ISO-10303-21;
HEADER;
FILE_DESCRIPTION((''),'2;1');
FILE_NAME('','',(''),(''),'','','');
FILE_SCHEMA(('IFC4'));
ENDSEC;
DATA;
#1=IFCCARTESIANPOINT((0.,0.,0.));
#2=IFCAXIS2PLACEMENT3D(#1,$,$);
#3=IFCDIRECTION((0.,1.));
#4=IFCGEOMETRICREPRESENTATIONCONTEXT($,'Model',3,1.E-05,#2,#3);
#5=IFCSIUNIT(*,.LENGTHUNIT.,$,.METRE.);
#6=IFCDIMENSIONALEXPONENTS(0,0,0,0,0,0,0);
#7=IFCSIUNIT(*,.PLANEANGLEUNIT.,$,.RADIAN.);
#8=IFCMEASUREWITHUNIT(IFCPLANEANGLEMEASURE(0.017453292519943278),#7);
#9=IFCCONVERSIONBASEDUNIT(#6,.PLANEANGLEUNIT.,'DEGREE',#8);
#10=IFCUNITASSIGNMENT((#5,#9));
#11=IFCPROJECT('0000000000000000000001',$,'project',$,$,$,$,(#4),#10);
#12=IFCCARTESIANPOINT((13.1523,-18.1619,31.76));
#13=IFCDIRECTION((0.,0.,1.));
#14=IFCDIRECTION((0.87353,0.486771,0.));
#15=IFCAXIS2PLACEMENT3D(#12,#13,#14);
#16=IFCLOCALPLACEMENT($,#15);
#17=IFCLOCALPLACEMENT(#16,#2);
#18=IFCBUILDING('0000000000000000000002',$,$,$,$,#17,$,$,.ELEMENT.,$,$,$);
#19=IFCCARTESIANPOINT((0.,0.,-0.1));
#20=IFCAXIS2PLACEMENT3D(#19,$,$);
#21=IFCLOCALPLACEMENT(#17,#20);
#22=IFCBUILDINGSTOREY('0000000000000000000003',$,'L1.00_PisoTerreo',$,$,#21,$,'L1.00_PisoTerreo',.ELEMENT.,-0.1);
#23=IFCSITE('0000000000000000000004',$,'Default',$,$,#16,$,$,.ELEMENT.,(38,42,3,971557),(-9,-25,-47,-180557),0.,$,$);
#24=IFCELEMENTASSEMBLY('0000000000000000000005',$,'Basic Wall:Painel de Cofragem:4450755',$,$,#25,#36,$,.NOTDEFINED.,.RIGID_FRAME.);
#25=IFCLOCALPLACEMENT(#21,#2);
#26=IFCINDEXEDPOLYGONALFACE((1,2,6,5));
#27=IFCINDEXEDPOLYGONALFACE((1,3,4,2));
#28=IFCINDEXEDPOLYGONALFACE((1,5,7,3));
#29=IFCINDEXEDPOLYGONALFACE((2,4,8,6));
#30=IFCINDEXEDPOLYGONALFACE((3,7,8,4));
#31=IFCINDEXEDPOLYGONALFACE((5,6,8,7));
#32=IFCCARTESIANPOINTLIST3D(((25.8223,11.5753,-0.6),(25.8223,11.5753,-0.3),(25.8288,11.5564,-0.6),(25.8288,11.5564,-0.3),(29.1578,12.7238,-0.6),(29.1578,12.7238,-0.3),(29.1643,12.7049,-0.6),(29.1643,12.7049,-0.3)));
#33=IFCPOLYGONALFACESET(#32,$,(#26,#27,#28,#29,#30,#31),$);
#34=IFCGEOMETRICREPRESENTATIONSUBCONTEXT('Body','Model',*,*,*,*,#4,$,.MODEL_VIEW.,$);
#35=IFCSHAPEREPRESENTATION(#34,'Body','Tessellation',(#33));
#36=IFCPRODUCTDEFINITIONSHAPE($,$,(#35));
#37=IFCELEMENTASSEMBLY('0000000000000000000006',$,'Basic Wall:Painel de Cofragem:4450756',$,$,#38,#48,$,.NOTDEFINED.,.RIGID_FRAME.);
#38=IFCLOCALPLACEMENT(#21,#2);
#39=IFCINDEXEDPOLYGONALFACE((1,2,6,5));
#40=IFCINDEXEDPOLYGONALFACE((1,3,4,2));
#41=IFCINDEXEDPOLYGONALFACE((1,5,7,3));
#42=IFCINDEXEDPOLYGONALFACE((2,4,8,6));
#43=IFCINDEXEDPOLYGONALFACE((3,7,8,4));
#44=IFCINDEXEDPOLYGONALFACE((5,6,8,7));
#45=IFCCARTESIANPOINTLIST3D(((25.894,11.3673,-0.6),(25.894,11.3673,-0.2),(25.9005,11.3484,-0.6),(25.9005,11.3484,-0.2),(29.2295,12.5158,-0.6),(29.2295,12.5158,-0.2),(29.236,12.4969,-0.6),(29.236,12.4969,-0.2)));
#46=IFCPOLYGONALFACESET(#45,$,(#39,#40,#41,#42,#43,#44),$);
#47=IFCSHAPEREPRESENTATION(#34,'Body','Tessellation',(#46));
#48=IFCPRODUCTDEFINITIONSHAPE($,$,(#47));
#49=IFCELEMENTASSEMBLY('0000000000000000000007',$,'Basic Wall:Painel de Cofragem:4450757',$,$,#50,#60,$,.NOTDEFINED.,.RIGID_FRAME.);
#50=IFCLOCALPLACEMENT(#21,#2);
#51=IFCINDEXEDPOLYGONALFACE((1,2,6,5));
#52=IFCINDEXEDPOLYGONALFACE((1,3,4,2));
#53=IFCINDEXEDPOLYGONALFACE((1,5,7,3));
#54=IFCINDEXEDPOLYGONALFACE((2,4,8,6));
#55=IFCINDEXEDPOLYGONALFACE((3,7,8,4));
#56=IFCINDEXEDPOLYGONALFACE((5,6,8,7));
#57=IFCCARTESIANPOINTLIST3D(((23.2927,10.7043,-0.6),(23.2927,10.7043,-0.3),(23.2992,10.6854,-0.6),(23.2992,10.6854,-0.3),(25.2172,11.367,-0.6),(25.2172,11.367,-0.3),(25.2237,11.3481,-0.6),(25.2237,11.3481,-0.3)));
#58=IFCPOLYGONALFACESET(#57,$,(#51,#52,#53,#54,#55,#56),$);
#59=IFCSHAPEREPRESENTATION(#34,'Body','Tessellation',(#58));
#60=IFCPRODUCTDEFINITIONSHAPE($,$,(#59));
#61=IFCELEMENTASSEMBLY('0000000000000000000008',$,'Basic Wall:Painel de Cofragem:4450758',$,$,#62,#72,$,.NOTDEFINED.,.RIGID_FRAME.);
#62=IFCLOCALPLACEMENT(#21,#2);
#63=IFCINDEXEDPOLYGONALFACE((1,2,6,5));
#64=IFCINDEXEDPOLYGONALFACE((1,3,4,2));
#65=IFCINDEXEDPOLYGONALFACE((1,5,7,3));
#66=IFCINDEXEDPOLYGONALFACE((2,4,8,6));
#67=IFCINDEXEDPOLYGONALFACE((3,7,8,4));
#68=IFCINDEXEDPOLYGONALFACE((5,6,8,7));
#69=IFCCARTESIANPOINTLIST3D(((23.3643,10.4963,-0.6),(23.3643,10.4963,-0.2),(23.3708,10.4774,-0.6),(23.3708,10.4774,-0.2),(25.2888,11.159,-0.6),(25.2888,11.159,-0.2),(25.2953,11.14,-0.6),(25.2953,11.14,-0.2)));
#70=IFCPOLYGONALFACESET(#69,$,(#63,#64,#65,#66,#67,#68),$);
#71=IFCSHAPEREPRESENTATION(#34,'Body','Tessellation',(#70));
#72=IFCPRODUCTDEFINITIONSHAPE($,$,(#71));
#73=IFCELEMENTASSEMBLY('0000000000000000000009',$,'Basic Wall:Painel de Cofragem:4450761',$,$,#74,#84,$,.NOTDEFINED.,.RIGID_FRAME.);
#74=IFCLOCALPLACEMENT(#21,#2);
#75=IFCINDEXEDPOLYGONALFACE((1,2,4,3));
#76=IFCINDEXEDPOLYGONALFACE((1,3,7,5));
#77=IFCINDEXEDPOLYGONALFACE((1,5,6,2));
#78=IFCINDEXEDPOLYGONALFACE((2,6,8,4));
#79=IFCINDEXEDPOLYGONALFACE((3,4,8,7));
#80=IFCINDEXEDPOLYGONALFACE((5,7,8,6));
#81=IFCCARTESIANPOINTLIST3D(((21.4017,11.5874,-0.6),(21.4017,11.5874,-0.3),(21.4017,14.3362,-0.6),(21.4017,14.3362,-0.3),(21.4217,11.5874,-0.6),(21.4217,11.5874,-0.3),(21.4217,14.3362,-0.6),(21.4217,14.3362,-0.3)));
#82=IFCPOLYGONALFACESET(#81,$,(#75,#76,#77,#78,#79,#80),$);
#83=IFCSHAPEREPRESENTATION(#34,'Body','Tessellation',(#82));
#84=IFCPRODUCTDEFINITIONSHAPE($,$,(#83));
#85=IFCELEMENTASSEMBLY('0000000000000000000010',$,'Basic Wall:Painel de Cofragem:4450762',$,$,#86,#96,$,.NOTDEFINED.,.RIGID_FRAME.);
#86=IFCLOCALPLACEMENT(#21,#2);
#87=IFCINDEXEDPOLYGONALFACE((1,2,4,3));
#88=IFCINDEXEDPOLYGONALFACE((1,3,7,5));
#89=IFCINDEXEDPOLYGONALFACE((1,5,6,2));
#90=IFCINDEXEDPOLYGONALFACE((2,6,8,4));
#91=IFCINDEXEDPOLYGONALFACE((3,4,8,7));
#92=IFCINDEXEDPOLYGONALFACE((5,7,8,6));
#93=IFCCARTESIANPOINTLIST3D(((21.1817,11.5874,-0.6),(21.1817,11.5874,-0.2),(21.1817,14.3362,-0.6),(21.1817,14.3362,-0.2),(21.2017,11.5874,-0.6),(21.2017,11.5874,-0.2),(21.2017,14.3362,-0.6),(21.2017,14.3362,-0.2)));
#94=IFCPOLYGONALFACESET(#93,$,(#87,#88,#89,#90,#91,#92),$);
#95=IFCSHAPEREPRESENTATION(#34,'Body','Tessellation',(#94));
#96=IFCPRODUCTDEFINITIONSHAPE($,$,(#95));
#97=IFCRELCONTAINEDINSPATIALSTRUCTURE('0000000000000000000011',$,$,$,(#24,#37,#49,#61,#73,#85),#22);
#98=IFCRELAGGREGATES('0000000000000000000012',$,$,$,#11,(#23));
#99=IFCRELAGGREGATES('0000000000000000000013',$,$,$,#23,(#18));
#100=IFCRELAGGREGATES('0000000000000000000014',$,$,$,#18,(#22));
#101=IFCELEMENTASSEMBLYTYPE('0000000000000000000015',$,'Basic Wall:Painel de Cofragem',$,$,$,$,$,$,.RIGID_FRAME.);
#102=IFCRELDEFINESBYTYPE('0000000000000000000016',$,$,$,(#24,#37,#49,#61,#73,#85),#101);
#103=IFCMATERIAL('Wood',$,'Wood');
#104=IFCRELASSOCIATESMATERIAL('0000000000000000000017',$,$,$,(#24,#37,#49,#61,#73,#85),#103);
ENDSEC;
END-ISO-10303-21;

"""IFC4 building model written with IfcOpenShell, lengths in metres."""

from ifc_helpers import new_model, entity, si_unit, converted_unit, direction, frame, origin, place, context, subcontext, project, spatial, indexed_curve, outline, extrude, material, type_object, element, save


model = new_model("IFC4")

# Units and contexts
model_context = context("Model", 3, precision=1e-05, world=origin(), true_north=direction((0.0, 1.0)))
body_context = subcontext(model_context, "Body", "Model", "MODEL_VIEW")
ifc_project = project(units=[si_unit("LENGTHUNIT", "METRE"), converted_unit("PLANEANGLEUNIT", "DEGREE", entity("IfcPlaneAngleMeasure", 0.017453292519943278), si_unit("PLANEANGLEUNIT", "RADIAN"), dimensions=[0, 0, 0, 0, 0, 0, 0])], contexts=[model_context])

# Site, building, storey
site_placement = place(None, frame((13.1523, -18.1619, 31.76), z_axis=(0.0, 0.0, 1.0), x_axis=(0.87353, 0.486771, 0.0)))
site = spatial("IfcSite", under=ifc_project, at=site_placement, Name="Default", CompositionType="ELEMENT", RefLatitude=(38, 42, 3, 971557), RefLongitude=(-9, -25, -47, -180557), RefElevation=0.0)
building_placement = place(site_placement, origin())
building = spatial("IfcBuilding", under=site, at=building_placement, CompositionType="ELEMENT")
storey_placement = place(building_placement, frame((0.0, 0.0, -0.1)))
storey = spatial("IfcBuildingStorey", under=building, at=storey_placement, Name="L1.00_PisoTerreo", LongName="L1.00_PisoTerreo", CompositionType="ELEMENT", Elevation=-0.1)

# Element assemblies
ifc_material_1 = material(Name="Wood", Category="Wood")
element_assembly_type = type_object("IfcElementAssemblyType", Name="Basic Wall:Painel de Cofragem", PredefinedType="RIGID_FRAME")
assembly_1_placement = place(storey_placement, frame((25.8256, 11.5659, -0.6), z_axis=(0.0, 0.0, 1.0), x_axis=(0.945519, 0.325568, 0.0)))
element("IfcElementAssembly", 1, at=assembly_1_placement, inside=storey, type_object=element_assembly_type, material=ifc_material_1, Name="Basic Wall:Painel de Cofragem:4450755", AssemblyPlace="NOTDEFINED", PredefinedType="RIGID_FRAME", context=body_context, shape_type="SweptSolid", body=[
    extrude(outline(indexed_curve([(3.5277, 0.01), (0.0, 0.01), (0.0, -0.01), (3.5277, -0.01), (3.5277, 0.01)], self_intersect=False)), origin(), (0.0, 0.0, 1.0), 0.3),
])
assembly_2_placement = place(storey_placement, frame((25.8972, 11.3579, -0.6), z_axis=(0.0, 0.0, 1.0), x_axis=(0.945519, 0.325568, 0.0)))
element("IfcElementAssembly", 2, at=assembly_2_placement, inside=storey, type_object=element_assembly_type, material=ifc_material_1, Name="Basic Wall:Painel de Cofragem:4450756", AssemblyPlace="NOTDEFINED", PredefinedType="RIGID_FRAME", context=body_context, shape_type="SweptSolid", body=[
    extrude(outline(indexed_curve([(3.5277, 0.01), (0.0, 0.01), (0.0, -0.01), (3.5277, -0.01), (3.5277, 0.01)], self_intersect=False)), origin(), (0.0, 0.0, 1.0), 0.4),
])
assembly_3_placement = place(storey_placement, frame((23.2959, 10.6949, -0.6), z_axis=(0.0, 0.0, 1.0), x_axis=(0.945519, 0.325568, 0.0)))
element("IfcElementAssembly", 3, at=assembly_3_placement, inside=storey, type_object=element_assembly_type, material=ifc_material_1, Name="Basic Wall:Painel de Cofragem:4450757", AssemblyPlace="NOTDEFINED", PredefinedType="RIGID_FRAME", context=body_context, shape_type="SweptSolid", body=[
    extrude(outline(indexed_curve([(2.0354, 0.01), (0.0, 0.01), (0.0, -0.01), (2.0354, -0.01), (2.0354, 0.01)], self_intersect=False)), origin(), (0.0, 0.0, 1.0), 0.3),
])
assembly_4_placement = place(storey_placement, frame((23.3676, 10.4868, -0.6), z_axis=(0.0, 0.0, 1.0), x_axis=(0.945519, 0.325568, 0.0)))
element("IfcElementAssembly", 4, at=assembly_4_placement, inside=storey, type_object=element_assembly_type, material=ifc_material_1, Name="Basic Wall:Painel de Cofragem:4450758", AssemblyPlace="NOTDEFINED", PredefinedType="RIGID_FRAME", context=body_context, shape_type="SweptSolid", body=[
    extrude(outline(indexed_curve([(2.0354, 0.01), (0.0, 0.01), (0.0, -0.01), (2.0354, -0.01), (2.0354, 0.01)], self_intersect=False)), origin(), (0.0, 0.0, 1.0), 0.4),
])
assembly_5_placement = place(storey_placement, frame((21.4117, 11.5874, -0.6), z_axis=(0.0, 0.0, 1.0), x_axis=(0.0, 1.0, 0.0)))
element("IfcElementAssembly", 5, at=assembly_5_placement, inside=storey, type_object=element_assembly_type, material=ifc_material_1, Name="Basic Wall:Painel de Cofragem:4450761", AssemblyPlace="NOTDEFINED", PredefinedType="RIGID_FRAME", context=body_context, shape_type="SweptSolid", body=[
    extrude(outline(indexed_curve([(2.7488, 0.01), (0.0, 0.01), (0.0, -0.01), (2.7488, -0.01), (2.7488, 0.01)], self_intersect=False)), origin(), (0.0, 0.0, 1.0), 0.3),
])
assembly_6_placement = place(storey_placement, frame((21.1917, 11.5874, -0.6), z_axis=(0.0, 0.0, 1.0), x_axis=(0.0, 1.0, 0.0)))
element("IfcElementAssembly", 6, at=assembly_6_placement, inside=storey, type_object=element_assembly_type, material=ifc_material_1, Name="Basic Wall:Painel de Cofragem:4450762", AssemblyPlace="NOTDEFINED", PredefinedType="RIGID_FRAME", context=body_context, shape_type="SweptSolid", body=[
    extrude(outline(indexed_curve([(2.7488, 0.01), (0.0, 0.01), (0.0, -0.01), (2.7488, -0.01), (2.7488, 0.01)], self_intersect=False)), origin(), (0.0, 0.0, 1.0), 0.4),
])

save(model, "model.ifc")
